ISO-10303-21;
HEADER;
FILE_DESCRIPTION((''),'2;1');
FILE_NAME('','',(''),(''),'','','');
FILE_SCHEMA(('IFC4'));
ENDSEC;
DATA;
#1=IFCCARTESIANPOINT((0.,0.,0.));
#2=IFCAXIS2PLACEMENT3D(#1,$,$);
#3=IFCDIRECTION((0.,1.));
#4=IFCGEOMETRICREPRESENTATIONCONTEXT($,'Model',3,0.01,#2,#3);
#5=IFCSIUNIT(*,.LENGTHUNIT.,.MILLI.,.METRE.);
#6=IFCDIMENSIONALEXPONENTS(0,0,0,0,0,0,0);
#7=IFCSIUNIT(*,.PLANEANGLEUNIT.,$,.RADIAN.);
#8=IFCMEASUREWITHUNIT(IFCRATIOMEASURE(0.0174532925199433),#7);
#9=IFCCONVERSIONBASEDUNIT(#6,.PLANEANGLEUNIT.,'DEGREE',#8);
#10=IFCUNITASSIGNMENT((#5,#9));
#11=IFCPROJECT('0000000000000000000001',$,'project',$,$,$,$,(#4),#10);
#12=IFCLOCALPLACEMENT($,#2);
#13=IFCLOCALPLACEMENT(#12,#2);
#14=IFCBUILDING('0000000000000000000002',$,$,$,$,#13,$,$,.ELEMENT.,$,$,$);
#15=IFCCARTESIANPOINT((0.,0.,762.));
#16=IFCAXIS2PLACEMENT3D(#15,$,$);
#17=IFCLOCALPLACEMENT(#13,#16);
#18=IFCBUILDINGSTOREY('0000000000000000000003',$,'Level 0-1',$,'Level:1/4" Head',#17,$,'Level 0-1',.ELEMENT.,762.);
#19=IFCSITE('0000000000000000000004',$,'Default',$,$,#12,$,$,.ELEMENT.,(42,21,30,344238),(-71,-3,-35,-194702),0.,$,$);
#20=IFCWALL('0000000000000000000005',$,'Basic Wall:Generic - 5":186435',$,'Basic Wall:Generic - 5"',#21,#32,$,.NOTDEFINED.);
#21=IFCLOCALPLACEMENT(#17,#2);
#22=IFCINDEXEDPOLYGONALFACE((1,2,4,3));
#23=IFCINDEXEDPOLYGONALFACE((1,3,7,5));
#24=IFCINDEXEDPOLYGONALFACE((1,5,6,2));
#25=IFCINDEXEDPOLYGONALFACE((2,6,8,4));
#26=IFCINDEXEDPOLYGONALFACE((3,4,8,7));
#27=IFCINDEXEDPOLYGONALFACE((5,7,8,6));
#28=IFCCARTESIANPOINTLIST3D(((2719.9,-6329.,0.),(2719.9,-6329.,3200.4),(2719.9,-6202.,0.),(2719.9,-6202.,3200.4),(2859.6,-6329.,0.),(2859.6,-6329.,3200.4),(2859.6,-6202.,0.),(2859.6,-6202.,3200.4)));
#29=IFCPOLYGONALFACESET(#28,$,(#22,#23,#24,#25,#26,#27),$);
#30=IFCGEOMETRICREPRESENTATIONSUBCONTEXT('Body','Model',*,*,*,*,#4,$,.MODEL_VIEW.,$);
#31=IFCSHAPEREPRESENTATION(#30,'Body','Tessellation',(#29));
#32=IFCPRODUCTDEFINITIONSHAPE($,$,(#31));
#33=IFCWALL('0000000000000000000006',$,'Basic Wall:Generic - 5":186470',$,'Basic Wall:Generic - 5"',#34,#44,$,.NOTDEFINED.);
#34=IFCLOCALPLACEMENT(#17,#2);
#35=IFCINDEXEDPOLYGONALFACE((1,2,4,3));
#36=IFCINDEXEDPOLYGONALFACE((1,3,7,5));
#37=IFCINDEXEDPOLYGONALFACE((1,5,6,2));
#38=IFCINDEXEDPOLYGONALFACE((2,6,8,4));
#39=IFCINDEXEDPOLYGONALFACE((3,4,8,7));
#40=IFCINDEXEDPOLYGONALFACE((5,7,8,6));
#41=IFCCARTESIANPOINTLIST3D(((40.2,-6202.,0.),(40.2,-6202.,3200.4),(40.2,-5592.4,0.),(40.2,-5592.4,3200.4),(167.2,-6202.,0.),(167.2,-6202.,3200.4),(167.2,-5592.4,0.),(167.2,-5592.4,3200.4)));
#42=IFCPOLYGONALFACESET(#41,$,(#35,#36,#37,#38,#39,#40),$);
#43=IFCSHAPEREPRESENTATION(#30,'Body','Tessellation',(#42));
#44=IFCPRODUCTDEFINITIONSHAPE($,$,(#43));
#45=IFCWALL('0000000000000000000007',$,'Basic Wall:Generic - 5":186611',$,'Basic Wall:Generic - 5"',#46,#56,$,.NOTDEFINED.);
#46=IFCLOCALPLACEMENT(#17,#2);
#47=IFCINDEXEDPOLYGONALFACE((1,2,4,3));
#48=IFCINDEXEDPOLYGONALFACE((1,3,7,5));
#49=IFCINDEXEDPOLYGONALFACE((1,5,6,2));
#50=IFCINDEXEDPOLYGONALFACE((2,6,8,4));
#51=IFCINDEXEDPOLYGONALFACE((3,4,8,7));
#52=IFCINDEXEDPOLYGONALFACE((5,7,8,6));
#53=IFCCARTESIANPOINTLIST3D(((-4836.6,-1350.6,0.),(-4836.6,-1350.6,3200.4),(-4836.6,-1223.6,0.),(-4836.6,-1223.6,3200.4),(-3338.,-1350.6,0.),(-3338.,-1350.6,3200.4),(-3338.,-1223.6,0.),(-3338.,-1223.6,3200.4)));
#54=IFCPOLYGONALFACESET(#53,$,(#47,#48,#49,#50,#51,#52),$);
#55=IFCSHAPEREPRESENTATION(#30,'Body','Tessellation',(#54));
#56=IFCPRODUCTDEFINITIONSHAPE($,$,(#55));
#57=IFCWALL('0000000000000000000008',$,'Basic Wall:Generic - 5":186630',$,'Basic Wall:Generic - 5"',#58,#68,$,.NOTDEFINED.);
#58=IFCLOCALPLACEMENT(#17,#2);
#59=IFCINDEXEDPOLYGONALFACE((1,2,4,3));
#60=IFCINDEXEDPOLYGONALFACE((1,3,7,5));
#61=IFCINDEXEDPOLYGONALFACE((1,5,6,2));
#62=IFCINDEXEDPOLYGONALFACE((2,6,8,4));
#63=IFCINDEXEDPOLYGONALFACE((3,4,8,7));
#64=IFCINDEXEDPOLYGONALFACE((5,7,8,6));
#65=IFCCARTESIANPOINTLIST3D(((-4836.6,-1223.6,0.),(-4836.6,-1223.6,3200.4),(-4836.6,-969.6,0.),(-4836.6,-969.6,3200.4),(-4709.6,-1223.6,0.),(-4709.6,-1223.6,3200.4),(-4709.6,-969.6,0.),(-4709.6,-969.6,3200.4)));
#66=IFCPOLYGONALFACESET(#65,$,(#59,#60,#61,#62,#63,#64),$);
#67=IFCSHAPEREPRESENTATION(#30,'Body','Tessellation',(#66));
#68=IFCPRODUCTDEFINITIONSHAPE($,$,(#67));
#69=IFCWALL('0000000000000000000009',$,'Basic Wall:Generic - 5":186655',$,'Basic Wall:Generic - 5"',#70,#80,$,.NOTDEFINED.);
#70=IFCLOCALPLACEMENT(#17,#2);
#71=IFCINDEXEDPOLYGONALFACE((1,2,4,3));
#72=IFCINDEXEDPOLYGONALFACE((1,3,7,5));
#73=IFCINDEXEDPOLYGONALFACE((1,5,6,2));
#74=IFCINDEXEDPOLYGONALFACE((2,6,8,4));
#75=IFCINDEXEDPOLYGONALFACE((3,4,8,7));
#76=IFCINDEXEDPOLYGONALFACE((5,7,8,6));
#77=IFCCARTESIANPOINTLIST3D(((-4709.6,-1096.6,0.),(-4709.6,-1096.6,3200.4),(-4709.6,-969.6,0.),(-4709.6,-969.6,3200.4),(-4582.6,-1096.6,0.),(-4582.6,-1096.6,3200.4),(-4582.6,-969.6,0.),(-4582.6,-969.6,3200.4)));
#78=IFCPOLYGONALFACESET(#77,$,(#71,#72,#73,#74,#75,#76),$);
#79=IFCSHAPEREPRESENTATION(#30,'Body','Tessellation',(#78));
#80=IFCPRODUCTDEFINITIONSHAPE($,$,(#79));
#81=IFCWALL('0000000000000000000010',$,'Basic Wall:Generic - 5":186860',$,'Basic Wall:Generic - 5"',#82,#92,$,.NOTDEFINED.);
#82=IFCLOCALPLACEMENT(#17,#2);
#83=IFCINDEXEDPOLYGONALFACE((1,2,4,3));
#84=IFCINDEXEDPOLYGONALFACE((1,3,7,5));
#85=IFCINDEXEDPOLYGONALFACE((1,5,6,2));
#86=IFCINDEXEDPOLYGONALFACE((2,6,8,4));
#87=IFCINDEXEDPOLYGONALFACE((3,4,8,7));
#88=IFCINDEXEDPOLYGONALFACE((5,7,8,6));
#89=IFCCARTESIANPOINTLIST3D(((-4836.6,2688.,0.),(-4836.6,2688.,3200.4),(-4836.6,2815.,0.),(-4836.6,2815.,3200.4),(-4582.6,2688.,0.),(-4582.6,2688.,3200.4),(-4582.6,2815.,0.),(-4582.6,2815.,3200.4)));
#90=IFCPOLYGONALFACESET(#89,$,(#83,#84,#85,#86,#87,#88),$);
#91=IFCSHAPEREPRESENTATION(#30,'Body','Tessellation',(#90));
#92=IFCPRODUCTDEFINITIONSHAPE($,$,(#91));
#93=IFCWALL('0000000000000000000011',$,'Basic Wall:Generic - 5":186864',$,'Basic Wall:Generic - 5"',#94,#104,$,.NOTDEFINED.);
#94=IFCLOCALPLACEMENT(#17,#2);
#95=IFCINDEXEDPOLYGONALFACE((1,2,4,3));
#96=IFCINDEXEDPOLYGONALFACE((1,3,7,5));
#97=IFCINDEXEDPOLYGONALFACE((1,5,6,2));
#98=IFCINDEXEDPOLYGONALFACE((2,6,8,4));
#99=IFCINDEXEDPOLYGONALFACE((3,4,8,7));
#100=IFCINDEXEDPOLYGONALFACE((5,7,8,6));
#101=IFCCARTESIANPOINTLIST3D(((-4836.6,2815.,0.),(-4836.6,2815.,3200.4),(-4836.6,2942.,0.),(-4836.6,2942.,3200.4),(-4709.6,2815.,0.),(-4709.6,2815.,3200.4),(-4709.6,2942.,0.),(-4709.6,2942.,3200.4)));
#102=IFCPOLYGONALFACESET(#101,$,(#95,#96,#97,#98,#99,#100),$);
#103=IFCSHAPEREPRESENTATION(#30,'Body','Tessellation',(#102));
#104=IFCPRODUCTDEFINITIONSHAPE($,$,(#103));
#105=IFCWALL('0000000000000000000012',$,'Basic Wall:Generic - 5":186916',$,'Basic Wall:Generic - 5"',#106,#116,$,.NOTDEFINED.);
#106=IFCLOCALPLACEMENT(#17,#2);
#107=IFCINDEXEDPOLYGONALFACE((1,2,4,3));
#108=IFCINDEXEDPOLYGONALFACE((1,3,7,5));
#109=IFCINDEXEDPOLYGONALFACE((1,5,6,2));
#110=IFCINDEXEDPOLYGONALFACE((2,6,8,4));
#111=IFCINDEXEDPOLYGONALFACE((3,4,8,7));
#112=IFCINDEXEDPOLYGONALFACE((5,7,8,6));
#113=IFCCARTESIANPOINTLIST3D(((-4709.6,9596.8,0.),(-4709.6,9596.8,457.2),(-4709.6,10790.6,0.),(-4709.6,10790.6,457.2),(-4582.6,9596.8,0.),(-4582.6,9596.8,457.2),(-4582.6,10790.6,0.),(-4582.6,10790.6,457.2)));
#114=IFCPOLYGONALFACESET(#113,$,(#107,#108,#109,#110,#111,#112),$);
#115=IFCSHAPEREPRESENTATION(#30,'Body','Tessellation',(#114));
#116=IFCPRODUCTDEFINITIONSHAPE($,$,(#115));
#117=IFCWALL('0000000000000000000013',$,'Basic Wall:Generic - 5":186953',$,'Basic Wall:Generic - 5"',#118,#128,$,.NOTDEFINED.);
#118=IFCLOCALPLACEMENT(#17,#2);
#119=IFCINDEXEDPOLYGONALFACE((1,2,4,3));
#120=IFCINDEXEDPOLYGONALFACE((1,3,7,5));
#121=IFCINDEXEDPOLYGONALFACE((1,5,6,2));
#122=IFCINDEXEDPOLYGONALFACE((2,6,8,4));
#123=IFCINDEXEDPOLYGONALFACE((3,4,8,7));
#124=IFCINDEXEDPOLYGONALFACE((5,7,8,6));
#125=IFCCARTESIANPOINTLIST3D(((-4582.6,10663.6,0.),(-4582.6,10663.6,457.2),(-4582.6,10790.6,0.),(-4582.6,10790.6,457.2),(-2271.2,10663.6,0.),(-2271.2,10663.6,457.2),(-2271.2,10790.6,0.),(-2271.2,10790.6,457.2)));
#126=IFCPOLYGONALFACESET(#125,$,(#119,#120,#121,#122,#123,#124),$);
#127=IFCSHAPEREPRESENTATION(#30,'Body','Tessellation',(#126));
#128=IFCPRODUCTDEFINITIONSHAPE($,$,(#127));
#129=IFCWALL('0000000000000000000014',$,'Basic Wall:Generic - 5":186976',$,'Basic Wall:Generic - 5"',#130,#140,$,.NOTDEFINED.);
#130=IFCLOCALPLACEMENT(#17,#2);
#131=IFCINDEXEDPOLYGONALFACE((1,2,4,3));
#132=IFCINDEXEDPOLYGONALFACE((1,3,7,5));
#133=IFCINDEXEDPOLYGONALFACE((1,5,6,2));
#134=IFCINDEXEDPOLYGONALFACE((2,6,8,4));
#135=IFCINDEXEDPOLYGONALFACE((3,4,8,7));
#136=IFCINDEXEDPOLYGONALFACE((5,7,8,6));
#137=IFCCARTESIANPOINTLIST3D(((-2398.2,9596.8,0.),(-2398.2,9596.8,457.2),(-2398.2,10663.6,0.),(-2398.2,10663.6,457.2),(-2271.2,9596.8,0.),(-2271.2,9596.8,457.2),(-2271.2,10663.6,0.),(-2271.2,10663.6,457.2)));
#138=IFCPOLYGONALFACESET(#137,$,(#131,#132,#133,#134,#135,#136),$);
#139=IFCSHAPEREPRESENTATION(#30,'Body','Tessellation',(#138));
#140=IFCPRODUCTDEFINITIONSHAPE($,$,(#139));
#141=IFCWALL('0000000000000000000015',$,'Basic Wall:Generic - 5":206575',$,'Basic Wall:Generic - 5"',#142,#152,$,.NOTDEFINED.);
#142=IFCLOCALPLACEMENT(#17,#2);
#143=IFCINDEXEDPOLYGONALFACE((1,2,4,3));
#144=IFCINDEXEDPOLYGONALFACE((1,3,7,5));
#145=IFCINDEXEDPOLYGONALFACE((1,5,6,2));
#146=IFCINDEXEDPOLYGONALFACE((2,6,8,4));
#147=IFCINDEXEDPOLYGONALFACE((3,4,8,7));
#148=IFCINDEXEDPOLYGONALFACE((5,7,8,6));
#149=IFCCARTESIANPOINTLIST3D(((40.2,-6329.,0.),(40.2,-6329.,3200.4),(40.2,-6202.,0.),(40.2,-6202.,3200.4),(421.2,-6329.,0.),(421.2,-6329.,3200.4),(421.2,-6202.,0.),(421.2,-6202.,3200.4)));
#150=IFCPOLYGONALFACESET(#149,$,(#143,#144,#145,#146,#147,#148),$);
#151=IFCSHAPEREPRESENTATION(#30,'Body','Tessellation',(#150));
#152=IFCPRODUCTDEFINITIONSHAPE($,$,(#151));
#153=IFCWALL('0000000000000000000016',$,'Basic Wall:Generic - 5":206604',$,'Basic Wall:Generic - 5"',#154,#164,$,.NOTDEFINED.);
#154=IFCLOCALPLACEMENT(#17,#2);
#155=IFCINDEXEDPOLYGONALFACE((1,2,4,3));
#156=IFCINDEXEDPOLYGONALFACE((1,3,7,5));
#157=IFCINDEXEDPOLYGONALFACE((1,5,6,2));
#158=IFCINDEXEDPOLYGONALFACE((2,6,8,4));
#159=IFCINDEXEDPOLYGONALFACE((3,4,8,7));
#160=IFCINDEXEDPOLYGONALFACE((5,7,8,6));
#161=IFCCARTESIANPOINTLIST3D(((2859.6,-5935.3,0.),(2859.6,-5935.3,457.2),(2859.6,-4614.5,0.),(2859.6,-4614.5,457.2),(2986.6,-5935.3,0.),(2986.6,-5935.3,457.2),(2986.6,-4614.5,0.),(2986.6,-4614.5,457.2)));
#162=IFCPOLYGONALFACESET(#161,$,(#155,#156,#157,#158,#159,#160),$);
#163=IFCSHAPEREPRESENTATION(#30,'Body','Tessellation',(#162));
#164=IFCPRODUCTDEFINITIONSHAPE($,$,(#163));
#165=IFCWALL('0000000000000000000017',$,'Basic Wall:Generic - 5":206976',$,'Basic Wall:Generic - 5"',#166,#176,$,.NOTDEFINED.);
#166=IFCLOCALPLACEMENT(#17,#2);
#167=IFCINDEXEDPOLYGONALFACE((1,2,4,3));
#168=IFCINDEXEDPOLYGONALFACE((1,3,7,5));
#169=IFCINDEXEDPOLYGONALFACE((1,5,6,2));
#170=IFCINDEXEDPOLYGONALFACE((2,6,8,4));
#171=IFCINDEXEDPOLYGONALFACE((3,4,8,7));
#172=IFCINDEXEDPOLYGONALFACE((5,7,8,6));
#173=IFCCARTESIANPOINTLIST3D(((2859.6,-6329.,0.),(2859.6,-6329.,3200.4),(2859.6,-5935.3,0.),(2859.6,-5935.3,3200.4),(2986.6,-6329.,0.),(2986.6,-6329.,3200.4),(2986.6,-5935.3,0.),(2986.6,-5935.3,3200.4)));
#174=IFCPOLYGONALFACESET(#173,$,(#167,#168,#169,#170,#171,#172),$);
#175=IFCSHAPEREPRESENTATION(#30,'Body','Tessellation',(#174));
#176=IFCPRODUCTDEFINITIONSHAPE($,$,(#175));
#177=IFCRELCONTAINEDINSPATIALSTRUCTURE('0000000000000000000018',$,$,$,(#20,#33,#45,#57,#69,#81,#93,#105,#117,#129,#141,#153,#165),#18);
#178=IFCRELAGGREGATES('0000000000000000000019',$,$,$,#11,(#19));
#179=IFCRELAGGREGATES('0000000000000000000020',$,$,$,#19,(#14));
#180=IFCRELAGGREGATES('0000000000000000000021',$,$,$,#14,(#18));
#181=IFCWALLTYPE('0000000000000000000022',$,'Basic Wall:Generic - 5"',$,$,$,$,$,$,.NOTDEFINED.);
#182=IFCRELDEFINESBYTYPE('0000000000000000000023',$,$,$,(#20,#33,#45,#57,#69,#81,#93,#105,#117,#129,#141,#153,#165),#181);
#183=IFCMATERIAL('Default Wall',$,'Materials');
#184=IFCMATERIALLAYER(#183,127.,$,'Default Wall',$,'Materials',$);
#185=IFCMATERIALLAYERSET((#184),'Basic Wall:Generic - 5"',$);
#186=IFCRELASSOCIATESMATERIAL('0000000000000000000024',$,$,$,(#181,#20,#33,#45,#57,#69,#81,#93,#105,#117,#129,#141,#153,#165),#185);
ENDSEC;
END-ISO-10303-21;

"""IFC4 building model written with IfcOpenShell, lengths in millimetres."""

from ifc_helpers import new_model, entity, si_unit, converted_unit, direction, frame, origin, place, context, subcontext, project, spatial, indexed_curve, outline, extrude, material, layer, layer_set, type_object, element, save


model = new_model("IFC4")

# Units and contexts
model_context = context("Model", 3, precision=0.01, world=origin(), true_north=direction((0.0, 1.0)))
body_context = subcontext(model_context, "Body", "Model", "MODEL_VIEW")
ifc_project = project(units=[si_unit("LENGTHUNIT", "METRE", prefix="MILLI"), converted_unit("PLANEANGLEUNIT", "DEGREE", entity("IfcRatioMeasure", 0.0174532925199433), si_unit("PLANEANGLEUNIT", "RADIAN"), dimensions=[0, 0, 0, 0, 0, 0, 0])], contexts=[model_context])

# Site, building, storey
site_placement = place(None, origin())
site = spatial("IfcSite", under=ifc_project, at=site_placement, Name="Default", CompositionType="ELEMENT", RefLatitude=(42, 21, 30, 344238), RefLongitude=(-71, -3, -35, -194702), RefElevation=0.0)
building_placement = place(site_placement, origin())
building = spatial("IfcBuilding", under=site, at=building_placement, CompositionType="ELEMENT")
storey_placement = place(building_placement, frame((0.0, 0.0, 762.0)))
storey = spatial("IfcBuildingStorey", under=building, at=storey_placement, Name="Level 0-1", ObjectType="Level:1/4\" Head", LongName="Level 0-1", CompositionType="ELEMENT", Elevation=762.0)

# Walls
ifc_material_1 = material(Name="Default Wall", Category="Materials")
ifc_layer_1 = layer(ifc_material_1, 127.0, Name="Default Wall", Category="Materials")
ifc_layer_set_1 = layer_set([ifc_layer_1], Name="Basic Wall:Generic - 5\"")
wall_type = type_object("IfcWallType", Name="Basic Wall:Generic - 5\"", PredefinedType="NOTDEFINED", material=ifc_layer_set_1)
wall_1_placement = place(storey_placement, frame((2859.6, -6265.5, 0.0), z_axis=(0.0, 0.0, 1.0), x_axis=(-1.0, 0.0, 0.0)))
element("IfcWall", 1, at=wall_1_placement, inside=storey, type_object=wall_type, material=ifc_layer_set_1, Name="Basic Wall:Generic - 5\":186435", ObjectType="Basic Wall:Generic - 5\"", PredefinedType="NOTDEFINED", context=body_context, shape_type="SweptSolid", body=[
    extrude(outline(indexed_curve([(139.7, 63.5), (0.0, 63.5), (0.0, -63.5), (139.7, -63.5), (139.7, 63.5)], self_intersect=False)), origin(), (0.0, 0.0, 1.0), 3200.4),
])
wall_2_placement = place(storey_placement, frame((103.7, -6202.0, 0.0), z_axis=(0.0, 0.0, 1.0), x_axis=(0.0, 1.0, 0.0)))
element("IfcWall", 2, at=wall_2_placement, inside=storey, type_object=wall_type, material=ifc_layer_set_1, Name="Basic Wall:Generic - 5\":186470", ObjectType="Basic Wall:Generic - 5\"", PredefinedType="NOTDEFINED", context=body_context, shape_type="SweptSolid", body=[
    extrude(outline(indexed_curve([(609.6, 63.5), (0.0, 63.5), (0.0, -63.5), (609.6, -63.5), (609.6, 63.5)], self_intersect=False)), origin(), (0.0, 0.0, 1.0), 3200.4),
])
wall_3_placement = place(storey_placement, frame((-3338.0, -1287.1, 0.0), z_axis=(0.0, 0.0, 1.0), x_axis=(-1.0, 0.0, 0.0)))
element("IfcWall", 3, at=wall_3_placement, inside=storey, type_object=wall_type, material=ifc_layer_set_1, Name="Basic Wall:Generic - 5\":186611", ObjectType="Basic Wall:Generic - 5\"", PredefinedType="NOTDEFINED", context=body_context, shape_type="SweptSolid", body=[
    extrude(outline(indexed_curve([(1498.6, 63.5), (0.0, 63.5), (0.0, -63.5), (1498.6, -63.5), (1498.6, 63.5)], self_intersect=False)), origin(), (0.0, 0.0, 1.0), 3200.4),
])
wall_4_placement = place(storey_placement, frame((-4773.1, -1223.6, 0.0), z_axis=(0.0, 0.0, 1.0), x_axis=(0.0, 1.0, 0.0)))
element("IfcWall", 4, at=wall_4_placement, inside=storey, type_object=wall_type, material=ifc_layer_set_1, Name="Basic Wall:Generic - 5\":186630", ObjectType="Basic Wall:Generic - 5\"", PredefinedType="NOTDEFINED", context=body_context, shape_type="SweptSolid", body=[
    extrude(outline(indexed_curve([(254.0, 63.5), (0.0, 63.5), (0.0, -63.5), (254.0, -63.5), (254.0, 63.5)], self_intersect=False)), origin(), (0.0, 0.0, 1.0), 3200.4),
])
wall_5_placement = place(storey_placement, frame((-4709.6, -1033.1, 0.0)))
element("IfcWall", 5, at=wall_5_placement, inside=storey, type_object=wall_type, material=ifc_layer_set_1, Name="Basic Wall:Generic - 5\":186655", ObjectType="Basic Wall:Generic - 5\"", PredefinedType="NOTDEFINED", context=body_context, shape_type="SweptSolid", body=[
    extrude(outline(indexed_curve([(127.0, 63.5), (0.0, 63.5), (0.0, -63.5), (127.0, -63.5), (127.0, 63.5)], self_intersect=False)), origin(), (0.0, 0.0, 1.0), 3200.4),
])
wall_6_placement = place(storey_placement, frame((-4582.6, 2751.5, 0.0), z_axis=(0.0, 0.0, 1.0), x_axis=(-1.0, 0.0, 0.0)))
element("IfcWall", 6, at=wall_6_placement, inside=storey, type_object=wall_type, material=ifc_layer_set_1, Name="Basic Wall:Generic - 5\":186860", ObjectType="Basic Wall:Generic - 5\"", PredefinedType="NOTDEFINED", context=body_context, shape_type="SweptSolid", body=[
    extrude(outline(indexed_curve([(254.0, 63.5), (0.0, 63.5), (0.0, -63.5), (254.0, -63.5), (254.0, 63.5)], self_intersect=False)), origin(), (0.0, 0.0, 1.0), 3200.4),
])
wall_7_placement = place(storey_placement, frame((-4773.1, 2815.0, 0.0), z_axis=(0.0, 0.0, 1.0), x_axis=(0.0, 1.0, 0.0)))
element("IfcWall", 7, at=wall_7_placement, inside=storey, type_object=wall_type, material=ifc_layer_set_1, Name="Basic Wall:Generic - 5\":186864", ObjectType="Basic Wall:Generic - 5\"", PredefinedType="NOTDEFINED", context=body_context, shape_type="SweptSolid", body=[
    extrude(outline(indexed_curve([(127.0, 63.5), (0.0, 63.5), (0.0, -63.5), (127.0, -63.5), (127.0, 63.5)], self_intersect=False)), origin(), (0.0, 0.0, 1.0), 3200.4),
])
wall_8_placement = place(storey_placement, frame((-4646.1, 9596.8, 0.0), z_axis=(0.0, 0.0, 1.0), x_axis=(0.0, 1.0, 0.0)))
element("IfcWall", 8, at=wall_8_placement, inside=storey, type_object=wall_type, material=ifc_layer_set_1, Name="Basic Wall:Generic - 5\":186916", ObjectType="Basic Wall:Generic - 5\"", PredefinedType="NOTDEFINED", context=body_context, shape_type="SweptSolid", body=[
    extrude(outline(indexed_curve([(1193.8, 63.5), (0.0, 63.5), (0.0, -63.5), (1193.8, -63.5), (1193.8, 63.5)], self_intersect=False)), origin(), (0.0, 0.0, 1.0), 457.2),
])
wall_9_placement = place(storey_placement, frame((-4582.6, 10727.1, 0.0)))
element("IfcWall", 9, at=wall_9_placement, inside=storey, type_object=wall_type, material=ifc_layer_set_1, Name="Basic Wall:Generic - 5\":186953", ObjectType="Basic Wall:Generic - 5\"", PredefinedType="NOTDEFINED", context=body_context, shape_type="SweptSolid", body=[
    extrude(outline(indexed_curve([(2311.4, 63.5), (0.0, 63.5), (0.0, -63.5), (2311.4, -63.5), (2311.4, 63.5)], self_intersect=False)), origin(), (0.0, 0.0, 1.0), 457.2),
])
wall_10_placement = place(storey_placement, frame((-2334.7, 10663.6, 0.0), z_axis=(0.0, 0.0, 1.0), x_axis=(0.0, -1.0, 0.0)))
element("IfcWall", 10, at=wall_10_placement, inside=storey, type_object=wall_type, material=ifc_layer_set_1, Name="Basic Wall:Generic - 5\":186976", ObjectType="Basic Wall:Generic - 5\"", PredefinedType="NOTDEFINED", context=body_context, shape_type="SweptSolid", body=[
    extrude(outline(indexed_curve([(1066.8, 63.5), (0.0, 63.5), (0.0, -63.5), (1066.8, -63.5), (1066.8, 63.5)], self_intersect=False)), origin(), (0.0, 0.0, 1.0), 457.2),
])
wall_11_placement = place(storey_placement, frame((421.2, -6265.5, 0.0), z_axis=(0.0, 0.0, 1.0), x_axis=(-1.0, 0.0, 0.0)))
element("IfcWall", 11, at=wall_11_placement, inside=storey, type_object=wall_type, material=ifc_layer_set_1, Name="Basic Wall:Generic - 5\":206575", ObjectType="Basic Wall:Generic - 5\"", PredefinedType="NOTDEFINED", context=body_context, shape_type="SweptSolid", body=[
    extrude(outline(indexed_curve([(381.0, 63.5), (0.0, 63.5), (0.0, -63.5), (381.0, -63.5), (381.0, 63.5)], self_intersect=False)), origin(), (0.0, 0.0, 1.0), 3200.4),
])
wall_12_placement = place(storey_placement, frame((2923.1, -4614.5, 0.0), z_axis=(0.0, 0.0, 1.0), x_axis=(0.0, -1.0, 0.0)))
element("IfcWall", 12, at=wall_12_placement, inside=storey, type_object=wall_type, material=ifc_layer_set_1, Name="Basic Wall:Generic - 5\":206604", ObjectType="Basic Wall:Generic - 5\"", PredefinedType="NOTDEFINED", context=body_context, shape_type="SweptSolid", body=[
    extrude(outline(indexed_curve([(1320.8, 63.5), (0.0, 63.5), (0.0, -63.5), (1320.8, -63.5), (1320.8, 63.5)], self_intersect=False)), origin(), (0.0, 0.0, 1.0), 457.2),
])
wall_13_placement = place(storey_placement, frame((2923.1, -5935.3, 0.0), z_axis=(0.0, 0.0, 1.0), x_axis=(0.0, -1.0, 0.0)))
element("IfcWall", 13, at=wall_13_placement, inside=storey, type_object=wall_type, material=ifc_layer_set_1, Name="Basic Wall:Generic - 5\":206976", ObjectType="Basic Wall:Generic - 5\"", PredefinedType="NOTDEFINED", context=body_context, shape_type="SweptSolid", body=[
    extrude(outline(indexed_curve([(393.7, 63.5), (0.0, 63.5), (0.0, -63.5), (393.7, -63.5), (393.7, 63.5)], self_intersect=False)), origin(), (0.0, 0.0, 1.0), 3200.4),
])

save(model, "model.ifc")
